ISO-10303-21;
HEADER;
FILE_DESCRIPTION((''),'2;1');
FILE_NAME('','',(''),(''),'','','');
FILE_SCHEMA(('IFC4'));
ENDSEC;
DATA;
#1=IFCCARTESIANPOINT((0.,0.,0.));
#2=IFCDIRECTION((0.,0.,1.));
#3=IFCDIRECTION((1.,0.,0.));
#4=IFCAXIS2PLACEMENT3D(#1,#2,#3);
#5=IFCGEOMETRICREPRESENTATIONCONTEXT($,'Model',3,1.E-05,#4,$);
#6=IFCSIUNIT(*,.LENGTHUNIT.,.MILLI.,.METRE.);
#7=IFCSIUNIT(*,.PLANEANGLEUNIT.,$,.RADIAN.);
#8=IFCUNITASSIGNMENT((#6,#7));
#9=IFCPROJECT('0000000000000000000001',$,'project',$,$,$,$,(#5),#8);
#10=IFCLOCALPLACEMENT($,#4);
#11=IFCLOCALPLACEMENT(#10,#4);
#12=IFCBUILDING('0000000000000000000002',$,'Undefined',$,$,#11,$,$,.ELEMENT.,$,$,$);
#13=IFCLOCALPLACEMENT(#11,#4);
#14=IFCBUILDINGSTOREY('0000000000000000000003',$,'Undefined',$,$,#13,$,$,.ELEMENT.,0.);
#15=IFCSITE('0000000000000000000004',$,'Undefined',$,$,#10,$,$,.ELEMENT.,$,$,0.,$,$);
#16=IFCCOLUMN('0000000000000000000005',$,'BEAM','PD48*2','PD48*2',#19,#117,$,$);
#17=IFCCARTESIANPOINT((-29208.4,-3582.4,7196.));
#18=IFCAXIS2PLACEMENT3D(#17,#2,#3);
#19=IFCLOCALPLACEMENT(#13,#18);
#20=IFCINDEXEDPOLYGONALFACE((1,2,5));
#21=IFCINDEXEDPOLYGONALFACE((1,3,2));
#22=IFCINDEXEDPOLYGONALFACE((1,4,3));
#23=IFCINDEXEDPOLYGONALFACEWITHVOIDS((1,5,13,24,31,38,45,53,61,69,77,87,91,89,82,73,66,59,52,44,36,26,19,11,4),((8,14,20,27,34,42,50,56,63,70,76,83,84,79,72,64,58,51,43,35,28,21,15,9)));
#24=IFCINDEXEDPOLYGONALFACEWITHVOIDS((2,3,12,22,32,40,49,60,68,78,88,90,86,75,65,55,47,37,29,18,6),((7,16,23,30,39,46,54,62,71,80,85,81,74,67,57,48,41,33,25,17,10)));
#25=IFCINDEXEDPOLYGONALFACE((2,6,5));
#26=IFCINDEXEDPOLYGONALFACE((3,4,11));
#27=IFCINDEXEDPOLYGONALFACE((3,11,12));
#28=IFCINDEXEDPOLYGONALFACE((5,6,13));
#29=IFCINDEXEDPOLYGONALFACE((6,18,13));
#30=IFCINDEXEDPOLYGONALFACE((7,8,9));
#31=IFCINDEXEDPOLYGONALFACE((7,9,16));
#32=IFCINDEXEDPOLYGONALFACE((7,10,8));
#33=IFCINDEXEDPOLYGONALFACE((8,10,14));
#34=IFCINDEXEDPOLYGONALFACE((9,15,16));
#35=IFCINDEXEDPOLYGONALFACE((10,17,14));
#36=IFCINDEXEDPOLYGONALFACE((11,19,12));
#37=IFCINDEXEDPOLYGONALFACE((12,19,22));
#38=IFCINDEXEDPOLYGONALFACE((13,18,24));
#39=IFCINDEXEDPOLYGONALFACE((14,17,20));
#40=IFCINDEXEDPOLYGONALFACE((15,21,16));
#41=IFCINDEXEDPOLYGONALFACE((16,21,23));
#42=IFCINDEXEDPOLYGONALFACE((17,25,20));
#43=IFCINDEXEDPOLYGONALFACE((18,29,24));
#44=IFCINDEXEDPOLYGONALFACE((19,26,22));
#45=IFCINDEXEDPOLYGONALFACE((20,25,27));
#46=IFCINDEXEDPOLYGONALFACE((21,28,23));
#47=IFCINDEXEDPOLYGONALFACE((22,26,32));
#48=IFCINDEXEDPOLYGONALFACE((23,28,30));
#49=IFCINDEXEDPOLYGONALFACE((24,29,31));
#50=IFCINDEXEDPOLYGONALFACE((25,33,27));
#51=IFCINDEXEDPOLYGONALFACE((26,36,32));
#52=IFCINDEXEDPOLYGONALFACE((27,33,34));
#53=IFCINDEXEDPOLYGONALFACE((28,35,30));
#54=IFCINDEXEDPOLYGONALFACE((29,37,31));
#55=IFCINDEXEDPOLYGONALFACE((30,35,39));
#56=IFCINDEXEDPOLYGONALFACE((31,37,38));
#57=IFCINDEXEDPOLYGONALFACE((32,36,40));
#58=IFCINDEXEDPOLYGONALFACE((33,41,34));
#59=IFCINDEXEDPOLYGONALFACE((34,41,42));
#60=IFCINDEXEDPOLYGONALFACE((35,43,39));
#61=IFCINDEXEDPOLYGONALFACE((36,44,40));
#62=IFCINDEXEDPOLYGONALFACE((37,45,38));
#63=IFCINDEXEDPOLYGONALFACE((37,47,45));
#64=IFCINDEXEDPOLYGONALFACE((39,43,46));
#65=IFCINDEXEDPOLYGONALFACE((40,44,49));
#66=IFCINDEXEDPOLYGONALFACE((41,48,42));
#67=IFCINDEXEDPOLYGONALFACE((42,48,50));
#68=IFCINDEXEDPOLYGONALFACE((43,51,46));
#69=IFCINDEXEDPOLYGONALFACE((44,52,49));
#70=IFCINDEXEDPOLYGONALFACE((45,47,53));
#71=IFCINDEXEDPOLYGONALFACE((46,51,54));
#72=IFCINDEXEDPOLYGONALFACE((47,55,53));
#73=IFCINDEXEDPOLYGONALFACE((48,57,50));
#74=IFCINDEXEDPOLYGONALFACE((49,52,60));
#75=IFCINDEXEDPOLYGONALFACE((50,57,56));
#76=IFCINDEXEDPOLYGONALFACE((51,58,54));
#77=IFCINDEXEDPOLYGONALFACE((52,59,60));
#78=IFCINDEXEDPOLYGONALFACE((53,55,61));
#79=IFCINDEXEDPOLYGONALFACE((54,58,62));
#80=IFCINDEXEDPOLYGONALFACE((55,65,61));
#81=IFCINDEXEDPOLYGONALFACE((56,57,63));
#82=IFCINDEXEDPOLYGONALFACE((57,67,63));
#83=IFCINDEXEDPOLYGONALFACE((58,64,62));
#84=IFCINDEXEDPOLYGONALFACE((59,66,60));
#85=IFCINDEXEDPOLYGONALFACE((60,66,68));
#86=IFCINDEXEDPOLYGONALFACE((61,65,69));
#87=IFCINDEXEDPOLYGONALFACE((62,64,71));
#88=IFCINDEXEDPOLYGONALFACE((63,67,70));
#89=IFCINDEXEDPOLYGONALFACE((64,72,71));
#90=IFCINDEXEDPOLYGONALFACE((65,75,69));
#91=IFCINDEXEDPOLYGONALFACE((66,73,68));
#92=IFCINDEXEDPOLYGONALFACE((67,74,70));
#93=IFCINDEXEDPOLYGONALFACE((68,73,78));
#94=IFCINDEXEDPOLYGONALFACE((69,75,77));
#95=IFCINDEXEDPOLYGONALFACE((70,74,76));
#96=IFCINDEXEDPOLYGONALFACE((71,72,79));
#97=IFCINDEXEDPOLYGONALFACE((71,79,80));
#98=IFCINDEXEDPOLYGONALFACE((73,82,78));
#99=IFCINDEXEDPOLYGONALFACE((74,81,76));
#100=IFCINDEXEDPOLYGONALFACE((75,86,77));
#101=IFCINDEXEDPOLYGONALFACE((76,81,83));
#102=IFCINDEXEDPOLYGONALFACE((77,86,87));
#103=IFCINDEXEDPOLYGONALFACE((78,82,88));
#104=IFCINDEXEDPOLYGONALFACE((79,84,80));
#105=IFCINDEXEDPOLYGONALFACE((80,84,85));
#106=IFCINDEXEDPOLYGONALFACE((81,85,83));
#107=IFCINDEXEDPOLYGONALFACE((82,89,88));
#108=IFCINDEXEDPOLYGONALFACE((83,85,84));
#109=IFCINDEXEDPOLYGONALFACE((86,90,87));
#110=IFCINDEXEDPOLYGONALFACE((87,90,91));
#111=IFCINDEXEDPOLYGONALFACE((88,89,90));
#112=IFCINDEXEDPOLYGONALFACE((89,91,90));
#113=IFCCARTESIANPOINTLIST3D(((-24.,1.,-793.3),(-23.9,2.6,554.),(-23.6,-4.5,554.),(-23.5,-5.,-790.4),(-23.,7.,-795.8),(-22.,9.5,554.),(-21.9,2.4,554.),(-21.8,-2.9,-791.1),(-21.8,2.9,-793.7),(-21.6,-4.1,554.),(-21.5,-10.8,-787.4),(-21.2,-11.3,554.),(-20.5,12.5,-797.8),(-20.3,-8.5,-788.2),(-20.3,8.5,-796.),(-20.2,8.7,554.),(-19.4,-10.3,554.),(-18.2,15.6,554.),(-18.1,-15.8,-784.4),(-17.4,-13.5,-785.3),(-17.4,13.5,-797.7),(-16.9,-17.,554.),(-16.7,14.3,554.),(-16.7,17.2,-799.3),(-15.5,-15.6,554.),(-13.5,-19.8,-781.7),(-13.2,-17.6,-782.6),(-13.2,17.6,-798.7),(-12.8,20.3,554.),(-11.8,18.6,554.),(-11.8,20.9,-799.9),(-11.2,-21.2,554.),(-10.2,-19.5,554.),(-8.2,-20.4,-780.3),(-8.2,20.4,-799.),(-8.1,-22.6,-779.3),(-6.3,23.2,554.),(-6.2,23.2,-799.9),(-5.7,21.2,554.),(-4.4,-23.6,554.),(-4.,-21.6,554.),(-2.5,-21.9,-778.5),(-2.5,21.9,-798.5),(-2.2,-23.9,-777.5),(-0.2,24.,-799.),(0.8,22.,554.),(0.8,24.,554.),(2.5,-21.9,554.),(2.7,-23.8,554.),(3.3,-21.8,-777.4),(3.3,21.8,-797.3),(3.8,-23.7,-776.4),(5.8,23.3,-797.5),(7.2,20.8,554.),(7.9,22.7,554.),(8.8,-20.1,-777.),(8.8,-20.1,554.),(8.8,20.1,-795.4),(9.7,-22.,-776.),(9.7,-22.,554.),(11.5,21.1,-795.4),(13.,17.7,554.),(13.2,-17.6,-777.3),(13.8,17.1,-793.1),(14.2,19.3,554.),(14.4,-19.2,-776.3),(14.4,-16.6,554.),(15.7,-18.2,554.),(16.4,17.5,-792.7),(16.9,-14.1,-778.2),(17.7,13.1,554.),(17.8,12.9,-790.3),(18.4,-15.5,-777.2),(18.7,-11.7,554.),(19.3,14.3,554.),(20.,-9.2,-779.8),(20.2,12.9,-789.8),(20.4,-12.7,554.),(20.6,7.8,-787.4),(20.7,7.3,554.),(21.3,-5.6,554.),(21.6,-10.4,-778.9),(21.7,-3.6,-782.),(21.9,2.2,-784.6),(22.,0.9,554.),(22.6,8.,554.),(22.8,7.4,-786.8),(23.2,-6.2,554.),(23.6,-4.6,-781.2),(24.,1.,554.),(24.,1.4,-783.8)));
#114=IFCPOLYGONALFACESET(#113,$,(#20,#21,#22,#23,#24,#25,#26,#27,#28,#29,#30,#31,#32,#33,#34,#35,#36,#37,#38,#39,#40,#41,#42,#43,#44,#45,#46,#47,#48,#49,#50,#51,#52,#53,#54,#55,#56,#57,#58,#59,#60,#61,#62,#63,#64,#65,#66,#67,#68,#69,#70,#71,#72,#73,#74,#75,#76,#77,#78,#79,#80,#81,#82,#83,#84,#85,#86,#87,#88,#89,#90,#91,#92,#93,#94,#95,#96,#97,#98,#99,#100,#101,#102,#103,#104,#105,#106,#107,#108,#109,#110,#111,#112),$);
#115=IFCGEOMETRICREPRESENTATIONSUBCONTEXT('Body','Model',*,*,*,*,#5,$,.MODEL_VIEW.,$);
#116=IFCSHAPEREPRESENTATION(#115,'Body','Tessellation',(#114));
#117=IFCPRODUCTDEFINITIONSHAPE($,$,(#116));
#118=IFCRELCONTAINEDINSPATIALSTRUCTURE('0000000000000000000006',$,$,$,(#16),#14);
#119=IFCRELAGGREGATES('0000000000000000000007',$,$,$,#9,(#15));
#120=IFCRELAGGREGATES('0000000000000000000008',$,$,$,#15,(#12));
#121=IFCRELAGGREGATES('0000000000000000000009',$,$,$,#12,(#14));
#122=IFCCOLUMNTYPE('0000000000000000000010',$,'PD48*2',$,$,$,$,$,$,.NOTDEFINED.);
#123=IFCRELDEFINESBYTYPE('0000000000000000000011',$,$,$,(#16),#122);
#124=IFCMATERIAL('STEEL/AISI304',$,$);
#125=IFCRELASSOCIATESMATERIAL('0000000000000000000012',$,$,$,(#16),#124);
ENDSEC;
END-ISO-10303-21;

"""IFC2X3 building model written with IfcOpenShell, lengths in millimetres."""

from ifc_helpers import new_model, si_unit, frame, origin_with_axes, origin_2d_with_axis, place, context, subcontext, project, spatial, hollow_circle, extrude, clip, halfspace, material, type_object, element, save


model = new_model("IFC2X3")

# Units and contexts
model_context = context("Model", 3, precision=1e-05, world=origin_with_axes())
body_context = subcontext(model_context, "Body", "Model", "MODEL_VIEW")
ifc_project = project(units=[si_unit("LENGTHUNIT", "METRE", prefix="MILLI"), si_unit("PLANEANGLEUNIT", "RADIAN")], contexts=[model_context])

# Site, building, storey
site_placement = place(None, origin_with_axes())
site = spatial("IfcSite", under=ifc_project, at=site_placement, Name="Undefined", CompositionType="ELEMENT", RefElevation=0.0)
building_placement = place(site_placement, origin_with_axes())
building = spatial("IfcBuilding", under=site, at=building_placement, Name="Undefined", CompositionType="ELEMENT")
storey_placement = place(building_placement, origin_with_axes())
storey = spatial("IfcBuildingStorey", under=building, at=storey_placement, Name="Undefined", CompositionType="ELEMENT", Elevation=0.0)

# Column
ifc_material_1 = material(Name="STEEL/AISI304")
column_type_1 = type_object("IfcColumnType", Name="PD48*2", PredefinedType="NOTDEFINED")
column_1_placement = place(storey_placement, frame((-29208.4, -3582.4, 7196.0), z_axis=(0.0, 0.0, 1.0), x_axis=(1.0, 0.0, 0.0)))
element("IfcColumn", 1, at=column_1_placement, inside=storey, type_object=column_type_1, material=ifc_material_1, Name="BEAM", Description="PD48*2", ObjectType="PD48*2", context=body_context, shape_type="Clipping", body=[
    clip(extrude(hollow_circle(Radius=24.0, WallThickness=2.0, at=origin_2d_with_axis()), frame((0.0, 0.0, 554.0), z_axis=(0.0, 0.0, -1.0), x_axis=(0.402197, -0.915553, 0.0)), (0.0, 0.0, 1.0), 1354.1), halfspace(frame((-9.7, 22.0, -800.0), z_axis=(0.179871, -0.409456, -0.894423), x_axis=(-0.915553, -0.402197, 0.0)), False)),
])

save(model, "model.ifc")
